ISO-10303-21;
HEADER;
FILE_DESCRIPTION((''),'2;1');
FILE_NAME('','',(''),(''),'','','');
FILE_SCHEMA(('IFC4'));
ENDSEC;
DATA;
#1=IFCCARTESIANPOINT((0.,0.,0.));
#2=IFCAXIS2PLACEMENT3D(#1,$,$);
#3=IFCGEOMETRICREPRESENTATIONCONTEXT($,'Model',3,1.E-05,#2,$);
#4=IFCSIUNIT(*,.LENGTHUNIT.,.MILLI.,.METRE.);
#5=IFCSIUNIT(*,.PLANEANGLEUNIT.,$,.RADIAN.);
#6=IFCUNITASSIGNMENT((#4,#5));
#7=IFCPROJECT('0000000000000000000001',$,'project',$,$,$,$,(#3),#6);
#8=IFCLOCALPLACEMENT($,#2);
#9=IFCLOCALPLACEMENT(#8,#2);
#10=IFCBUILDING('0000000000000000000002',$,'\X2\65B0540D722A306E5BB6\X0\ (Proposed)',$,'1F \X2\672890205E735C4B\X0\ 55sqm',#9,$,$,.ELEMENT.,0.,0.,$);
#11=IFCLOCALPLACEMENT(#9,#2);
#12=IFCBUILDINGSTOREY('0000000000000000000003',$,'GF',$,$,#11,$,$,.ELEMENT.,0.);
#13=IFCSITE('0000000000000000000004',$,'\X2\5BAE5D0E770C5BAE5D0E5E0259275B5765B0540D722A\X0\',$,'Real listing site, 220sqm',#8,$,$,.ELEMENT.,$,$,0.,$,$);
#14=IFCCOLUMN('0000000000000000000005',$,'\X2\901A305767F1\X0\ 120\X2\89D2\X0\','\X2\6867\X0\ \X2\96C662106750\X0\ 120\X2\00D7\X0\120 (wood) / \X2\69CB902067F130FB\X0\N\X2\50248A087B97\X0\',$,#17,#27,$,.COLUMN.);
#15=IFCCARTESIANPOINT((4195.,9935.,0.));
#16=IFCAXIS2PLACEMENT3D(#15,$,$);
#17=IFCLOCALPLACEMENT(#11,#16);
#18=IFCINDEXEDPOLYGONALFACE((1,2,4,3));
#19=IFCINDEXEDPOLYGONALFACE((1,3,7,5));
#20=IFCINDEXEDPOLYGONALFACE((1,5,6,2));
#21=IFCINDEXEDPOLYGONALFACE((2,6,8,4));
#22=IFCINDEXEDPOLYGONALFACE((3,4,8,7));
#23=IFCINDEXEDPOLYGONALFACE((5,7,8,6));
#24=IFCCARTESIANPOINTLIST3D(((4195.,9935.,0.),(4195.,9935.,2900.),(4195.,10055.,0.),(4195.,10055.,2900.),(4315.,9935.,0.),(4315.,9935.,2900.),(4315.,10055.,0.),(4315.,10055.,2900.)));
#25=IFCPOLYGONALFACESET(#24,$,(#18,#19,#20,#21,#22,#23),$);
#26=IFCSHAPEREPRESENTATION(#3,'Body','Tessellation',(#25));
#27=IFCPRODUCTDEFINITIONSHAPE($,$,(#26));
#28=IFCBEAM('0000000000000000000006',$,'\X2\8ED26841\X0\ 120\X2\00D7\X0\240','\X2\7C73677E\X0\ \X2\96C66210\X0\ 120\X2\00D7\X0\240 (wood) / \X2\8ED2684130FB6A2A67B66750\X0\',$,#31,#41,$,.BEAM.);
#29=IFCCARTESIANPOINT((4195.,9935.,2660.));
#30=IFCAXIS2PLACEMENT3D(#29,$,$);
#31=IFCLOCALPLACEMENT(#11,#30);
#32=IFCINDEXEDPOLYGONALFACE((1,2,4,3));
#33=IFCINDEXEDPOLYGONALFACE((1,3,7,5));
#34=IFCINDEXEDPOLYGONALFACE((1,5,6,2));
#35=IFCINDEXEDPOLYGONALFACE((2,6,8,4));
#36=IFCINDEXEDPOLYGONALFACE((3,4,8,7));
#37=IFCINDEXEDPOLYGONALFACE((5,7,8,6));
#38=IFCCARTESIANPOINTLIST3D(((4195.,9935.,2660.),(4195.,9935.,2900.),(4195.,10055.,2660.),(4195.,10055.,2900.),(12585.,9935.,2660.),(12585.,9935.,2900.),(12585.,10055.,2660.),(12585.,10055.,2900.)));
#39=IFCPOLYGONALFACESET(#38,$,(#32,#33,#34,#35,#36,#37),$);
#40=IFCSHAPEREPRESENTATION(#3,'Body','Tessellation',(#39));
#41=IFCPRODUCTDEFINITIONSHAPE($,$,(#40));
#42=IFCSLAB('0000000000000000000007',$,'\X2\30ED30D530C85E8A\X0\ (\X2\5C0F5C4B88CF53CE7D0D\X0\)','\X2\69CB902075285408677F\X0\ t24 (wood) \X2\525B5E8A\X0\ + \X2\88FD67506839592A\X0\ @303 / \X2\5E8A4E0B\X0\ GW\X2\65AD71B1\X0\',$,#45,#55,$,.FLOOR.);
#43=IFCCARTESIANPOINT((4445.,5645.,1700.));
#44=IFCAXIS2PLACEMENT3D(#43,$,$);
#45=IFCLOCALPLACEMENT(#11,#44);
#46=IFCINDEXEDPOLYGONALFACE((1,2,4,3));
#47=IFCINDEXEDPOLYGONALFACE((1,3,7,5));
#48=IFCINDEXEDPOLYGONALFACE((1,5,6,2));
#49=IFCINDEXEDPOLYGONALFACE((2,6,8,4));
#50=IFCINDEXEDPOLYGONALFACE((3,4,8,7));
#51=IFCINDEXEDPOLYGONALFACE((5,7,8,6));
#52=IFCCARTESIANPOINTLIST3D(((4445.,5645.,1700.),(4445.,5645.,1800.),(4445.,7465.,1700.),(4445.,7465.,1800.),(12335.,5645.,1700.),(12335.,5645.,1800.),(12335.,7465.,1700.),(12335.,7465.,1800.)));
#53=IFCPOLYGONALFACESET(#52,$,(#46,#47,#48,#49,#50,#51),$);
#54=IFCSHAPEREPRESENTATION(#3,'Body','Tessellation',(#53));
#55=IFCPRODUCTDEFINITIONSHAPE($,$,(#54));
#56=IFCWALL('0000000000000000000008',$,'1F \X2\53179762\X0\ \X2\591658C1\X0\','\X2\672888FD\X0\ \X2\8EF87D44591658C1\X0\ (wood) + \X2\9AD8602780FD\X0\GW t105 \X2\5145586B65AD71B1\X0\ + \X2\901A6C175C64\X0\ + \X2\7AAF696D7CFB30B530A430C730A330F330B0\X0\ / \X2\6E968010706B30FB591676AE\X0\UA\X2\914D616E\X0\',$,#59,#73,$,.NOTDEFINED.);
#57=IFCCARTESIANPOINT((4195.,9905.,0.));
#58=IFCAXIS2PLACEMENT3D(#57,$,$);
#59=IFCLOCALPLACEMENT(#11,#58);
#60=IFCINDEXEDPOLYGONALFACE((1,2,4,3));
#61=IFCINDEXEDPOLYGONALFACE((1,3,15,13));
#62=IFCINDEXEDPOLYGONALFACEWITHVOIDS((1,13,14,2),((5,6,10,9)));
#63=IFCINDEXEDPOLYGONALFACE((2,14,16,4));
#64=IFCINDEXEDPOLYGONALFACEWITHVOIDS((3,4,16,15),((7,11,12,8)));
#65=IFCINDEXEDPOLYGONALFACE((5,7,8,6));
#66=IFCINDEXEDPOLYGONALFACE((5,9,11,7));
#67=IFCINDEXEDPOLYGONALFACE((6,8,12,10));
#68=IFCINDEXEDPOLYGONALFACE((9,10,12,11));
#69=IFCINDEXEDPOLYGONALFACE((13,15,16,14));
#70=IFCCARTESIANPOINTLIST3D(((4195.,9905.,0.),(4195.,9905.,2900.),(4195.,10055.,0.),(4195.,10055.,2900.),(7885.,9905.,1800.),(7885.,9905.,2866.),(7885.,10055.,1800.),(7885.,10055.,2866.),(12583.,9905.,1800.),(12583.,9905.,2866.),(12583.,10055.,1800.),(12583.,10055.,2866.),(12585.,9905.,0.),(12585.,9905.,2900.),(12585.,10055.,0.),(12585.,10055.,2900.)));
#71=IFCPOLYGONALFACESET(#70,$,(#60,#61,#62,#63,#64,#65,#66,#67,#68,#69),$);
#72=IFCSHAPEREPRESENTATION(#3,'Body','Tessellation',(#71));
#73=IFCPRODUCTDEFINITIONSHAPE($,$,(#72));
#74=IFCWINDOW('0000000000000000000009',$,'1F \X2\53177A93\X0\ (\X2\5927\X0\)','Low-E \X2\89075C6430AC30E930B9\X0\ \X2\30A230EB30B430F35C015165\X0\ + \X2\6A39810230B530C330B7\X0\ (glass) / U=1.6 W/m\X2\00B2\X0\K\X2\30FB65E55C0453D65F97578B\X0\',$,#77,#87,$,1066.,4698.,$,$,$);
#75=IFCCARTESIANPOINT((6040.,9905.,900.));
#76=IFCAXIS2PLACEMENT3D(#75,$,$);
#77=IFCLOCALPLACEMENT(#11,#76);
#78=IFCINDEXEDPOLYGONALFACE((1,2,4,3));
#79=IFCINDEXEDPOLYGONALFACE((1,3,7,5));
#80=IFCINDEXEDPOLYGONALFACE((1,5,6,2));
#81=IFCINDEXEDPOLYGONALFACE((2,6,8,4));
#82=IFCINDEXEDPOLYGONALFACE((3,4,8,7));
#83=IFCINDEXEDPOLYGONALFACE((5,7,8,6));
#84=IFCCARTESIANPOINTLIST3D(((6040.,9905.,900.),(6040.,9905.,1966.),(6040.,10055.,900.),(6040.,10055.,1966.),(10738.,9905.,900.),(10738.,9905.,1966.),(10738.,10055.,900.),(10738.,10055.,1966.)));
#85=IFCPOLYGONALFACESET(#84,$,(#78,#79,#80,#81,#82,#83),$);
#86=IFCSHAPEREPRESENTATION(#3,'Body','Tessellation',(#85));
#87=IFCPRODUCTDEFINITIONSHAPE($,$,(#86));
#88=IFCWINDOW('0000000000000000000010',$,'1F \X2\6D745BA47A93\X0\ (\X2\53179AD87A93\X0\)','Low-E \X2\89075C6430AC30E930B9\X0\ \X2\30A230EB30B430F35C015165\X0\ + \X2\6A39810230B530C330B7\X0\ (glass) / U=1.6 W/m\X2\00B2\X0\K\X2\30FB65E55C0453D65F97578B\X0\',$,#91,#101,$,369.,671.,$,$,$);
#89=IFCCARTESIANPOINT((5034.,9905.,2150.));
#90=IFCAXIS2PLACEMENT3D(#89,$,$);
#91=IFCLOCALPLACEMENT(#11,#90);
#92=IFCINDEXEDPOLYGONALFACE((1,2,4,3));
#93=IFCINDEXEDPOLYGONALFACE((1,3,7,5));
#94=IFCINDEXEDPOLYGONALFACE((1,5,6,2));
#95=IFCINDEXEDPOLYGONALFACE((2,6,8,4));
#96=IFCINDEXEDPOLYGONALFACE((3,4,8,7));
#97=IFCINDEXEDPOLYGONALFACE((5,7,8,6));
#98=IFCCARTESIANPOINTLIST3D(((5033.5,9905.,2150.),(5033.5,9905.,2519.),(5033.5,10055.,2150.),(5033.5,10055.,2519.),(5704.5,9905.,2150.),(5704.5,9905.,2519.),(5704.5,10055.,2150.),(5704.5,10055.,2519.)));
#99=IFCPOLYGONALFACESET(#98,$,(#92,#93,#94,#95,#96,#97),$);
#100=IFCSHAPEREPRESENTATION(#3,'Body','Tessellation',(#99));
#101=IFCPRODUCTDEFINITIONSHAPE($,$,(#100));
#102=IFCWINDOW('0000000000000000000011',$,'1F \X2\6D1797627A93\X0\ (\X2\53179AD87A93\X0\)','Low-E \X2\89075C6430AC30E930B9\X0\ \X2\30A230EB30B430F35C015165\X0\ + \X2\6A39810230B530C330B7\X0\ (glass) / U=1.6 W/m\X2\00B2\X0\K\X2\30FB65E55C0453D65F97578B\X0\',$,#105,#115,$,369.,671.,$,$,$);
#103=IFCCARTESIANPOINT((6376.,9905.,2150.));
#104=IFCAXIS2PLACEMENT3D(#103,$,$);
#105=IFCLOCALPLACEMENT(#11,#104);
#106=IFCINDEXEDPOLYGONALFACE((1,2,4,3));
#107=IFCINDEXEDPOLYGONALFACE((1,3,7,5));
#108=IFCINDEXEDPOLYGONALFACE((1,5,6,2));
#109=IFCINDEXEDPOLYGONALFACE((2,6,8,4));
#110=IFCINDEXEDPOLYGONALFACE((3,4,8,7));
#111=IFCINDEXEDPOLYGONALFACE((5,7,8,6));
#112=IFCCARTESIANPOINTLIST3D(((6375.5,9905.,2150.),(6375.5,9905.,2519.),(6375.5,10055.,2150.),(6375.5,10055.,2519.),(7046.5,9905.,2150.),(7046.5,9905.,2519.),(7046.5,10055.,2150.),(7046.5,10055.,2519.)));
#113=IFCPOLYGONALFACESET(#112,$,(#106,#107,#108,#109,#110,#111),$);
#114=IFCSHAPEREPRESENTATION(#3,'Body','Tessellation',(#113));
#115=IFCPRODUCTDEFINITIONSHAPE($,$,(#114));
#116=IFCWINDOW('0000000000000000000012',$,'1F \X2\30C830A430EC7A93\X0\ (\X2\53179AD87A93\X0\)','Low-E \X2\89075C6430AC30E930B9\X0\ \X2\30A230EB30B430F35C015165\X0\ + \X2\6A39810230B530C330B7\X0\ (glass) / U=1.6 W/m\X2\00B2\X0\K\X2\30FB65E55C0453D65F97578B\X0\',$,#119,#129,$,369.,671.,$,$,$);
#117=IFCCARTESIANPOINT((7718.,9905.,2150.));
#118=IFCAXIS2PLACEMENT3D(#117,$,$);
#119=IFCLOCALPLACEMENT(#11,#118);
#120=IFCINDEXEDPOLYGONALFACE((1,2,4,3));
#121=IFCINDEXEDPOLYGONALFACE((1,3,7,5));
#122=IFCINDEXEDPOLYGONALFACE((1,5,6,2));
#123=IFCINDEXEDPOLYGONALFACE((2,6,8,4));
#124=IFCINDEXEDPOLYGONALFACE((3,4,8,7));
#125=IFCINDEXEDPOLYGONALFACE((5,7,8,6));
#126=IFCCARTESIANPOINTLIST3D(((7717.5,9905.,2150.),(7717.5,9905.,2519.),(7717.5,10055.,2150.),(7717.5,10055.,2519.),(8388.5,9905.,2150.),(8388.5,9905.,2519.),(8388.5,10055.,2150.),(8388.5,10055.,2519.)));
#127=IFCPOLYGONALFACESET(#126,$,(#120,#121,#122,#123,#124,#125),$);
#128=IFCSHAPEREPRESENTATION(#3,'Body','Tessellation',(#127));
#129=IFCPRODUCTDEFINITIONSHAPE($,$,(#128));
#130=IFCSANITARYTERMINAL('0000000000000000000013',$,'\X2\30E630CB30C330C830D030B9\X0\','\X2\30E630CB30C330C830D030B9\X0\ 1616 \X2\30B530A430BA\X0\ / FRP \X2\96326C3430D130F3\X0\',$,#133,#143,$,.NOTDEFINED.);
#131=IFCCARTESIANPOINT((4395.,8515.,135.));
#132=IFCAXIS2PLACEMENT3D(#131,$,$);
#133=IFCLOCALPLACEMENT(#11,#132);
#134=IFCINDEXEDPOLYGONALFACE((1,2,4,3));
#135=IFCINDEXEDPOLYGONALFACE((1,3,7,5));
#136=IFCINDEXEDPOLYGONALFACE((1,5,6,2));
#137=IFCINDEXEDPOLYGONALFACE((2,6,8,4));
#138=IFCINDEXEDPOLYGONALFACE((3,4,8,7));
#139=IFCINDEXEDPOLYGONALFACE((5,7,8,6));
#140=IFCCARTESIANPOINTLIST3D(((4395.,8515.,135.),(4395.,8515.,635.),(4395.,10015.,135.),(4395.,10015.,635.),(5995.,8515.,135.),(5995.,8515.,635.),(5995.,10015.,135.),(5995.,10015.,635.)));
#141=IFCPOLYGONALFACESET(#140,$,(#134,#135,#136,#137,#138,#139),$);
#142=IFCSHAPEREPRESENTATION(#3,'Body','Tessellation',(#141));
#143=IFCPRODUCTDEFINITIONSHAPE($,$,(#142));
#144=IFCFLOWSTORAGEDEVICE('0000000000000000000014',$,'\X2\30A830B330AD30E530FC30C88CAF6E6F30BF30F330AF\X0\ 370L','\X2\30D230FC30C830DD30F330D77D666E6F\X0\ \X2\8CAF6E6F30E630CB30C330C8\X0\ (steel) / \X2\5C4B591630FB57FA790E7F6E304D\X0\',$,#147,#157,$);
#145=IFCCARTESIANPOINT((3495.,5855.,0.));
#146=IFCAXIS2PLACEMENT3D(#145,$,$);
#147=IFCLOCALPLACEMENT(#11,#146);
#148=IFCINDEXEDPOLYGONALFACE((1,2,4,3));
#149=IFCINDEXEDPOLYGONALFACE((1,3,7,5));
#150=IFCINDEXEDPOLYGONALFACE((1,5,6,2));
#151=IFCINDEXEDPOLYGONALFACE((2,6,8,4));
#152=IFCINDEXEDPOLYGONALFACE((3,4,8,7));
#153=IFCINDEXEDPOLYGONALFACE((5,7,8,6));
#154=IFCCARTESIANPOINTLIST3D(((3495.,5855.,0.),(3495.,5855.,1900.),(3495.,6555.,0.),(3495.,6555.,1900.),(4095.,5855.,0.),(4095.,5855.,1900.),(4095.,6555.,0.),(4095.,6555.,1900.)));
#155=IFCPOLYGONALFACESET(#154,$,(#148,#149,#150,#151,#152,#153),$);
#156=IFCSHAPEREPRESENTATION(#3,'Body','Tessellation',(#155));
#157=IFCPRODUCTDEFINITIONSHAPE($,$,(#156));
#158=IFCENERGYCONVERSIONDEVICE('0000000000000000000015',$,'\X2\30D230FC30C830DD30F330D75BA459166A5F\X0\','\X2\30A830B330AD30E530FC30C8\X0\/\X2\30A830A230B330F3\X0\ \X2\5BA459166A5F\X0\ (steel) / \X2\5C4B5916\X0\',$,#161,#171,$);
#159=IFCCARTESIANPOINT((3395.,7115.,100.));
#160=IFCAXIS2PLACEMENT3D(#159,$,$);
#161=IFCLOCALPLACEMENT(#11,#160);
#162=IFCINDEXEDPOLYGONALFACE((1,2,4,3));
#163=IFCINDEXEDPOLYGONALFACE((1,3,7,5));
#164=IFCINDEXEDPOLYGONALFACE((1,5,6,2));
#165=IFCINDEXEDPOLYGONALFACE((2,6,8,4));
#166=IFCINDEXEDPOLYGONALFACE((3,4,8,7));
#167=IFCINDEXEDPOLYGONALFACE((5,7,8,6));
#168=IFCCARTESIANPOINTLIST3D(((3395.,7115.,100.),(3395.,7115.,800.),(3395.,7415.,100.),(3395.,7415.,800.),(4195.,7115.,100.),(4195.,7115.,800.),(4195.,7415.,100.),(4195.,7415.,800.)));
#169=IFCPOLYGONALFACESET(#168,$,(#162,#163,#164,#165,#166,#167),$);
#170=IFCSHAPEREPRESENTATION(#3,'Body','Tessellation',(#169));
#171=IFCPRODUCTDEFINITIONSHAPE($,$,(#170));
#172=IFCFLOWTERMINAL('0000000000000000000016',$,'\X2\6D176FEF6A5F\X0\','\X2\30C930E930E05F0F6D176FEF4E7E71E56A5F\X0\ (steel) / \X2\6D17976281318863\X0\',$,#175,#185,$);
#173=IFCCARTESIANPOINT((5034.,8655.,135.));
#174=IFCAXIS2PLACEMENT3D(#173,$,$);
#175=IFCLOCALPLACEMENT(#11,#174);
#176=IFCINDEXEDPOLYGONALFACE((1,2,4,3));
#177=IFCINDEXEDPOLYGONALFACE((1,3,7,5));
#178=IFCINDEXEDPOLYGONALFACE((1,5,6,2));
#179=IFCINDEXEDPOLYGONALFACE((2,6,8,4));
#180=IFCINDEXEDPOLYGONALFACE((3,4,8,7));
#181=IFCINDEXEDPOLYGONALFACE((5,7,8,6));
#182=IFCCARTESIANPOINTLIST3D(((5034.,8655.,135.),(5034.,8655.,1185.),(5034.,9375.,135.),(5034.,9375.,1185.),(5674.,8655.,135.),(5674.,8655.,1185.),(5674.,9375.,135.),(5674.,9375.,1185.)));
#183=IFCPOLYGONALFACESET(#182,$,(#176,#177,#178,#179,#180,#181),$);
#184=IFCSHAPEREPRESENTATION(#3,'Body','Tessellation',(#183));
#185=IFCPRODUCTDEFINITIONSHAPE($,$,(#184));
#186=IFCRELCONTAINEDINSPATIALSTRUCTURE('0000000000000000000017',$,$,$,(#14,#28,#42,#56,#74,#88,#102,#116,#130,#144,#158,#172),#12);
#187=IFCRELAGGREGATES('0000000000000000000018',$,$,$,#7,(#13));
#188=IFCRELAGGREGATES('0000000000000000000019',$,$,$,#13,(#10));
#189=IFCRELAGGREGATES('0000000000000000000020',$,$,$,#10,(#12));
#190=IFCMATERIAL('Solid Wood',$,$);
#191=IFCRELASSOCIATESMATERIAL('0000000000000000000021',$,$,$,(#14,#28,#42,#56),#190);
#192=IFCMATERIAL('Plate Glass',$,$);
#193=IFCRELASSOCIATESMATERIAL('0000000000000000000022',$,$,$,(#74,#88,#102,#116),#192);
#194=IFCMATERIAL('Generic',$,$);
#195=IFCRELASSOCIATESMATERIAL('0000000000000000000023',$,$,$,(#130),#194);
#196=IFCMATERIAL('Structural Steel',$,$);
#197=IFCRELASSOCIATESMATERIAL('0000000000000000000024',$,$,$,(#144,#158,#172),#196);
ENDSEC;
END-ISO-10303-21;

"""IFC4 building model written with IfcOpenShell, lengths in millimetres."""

from ifc_helpers import new_model, si_unit, frame, frame_2d, origin, place, context, project, spatial, rectangle, extrude, material, element, fill, save


model = new_model("IFC4")

# Units and contexts
model_context = context("Model", 3, precision=1e-05, world=origin())
ifc_project = project(units=[si_unit("LENGTHUNIT", "METRE", prefix="MILLI"), si_unit("PLANEANGLEUNIT", "RADIAN")], contexts=[model_context])

# Site, building, storey
site_placement = place(None, origin())
site = spatial("IfcSite", under=ifc_project, at=site_placement, Name="宮崎県宮崎市大字新名爪", ObjectType="Real listing site, 220sqm", CompositionType="ELEMENT", RefElevation=0.0)
building_placement = place(site_placement, origin())
building = spatial("IfcBuilding", under=site, at=building_placement, Name="新名爪の家 (Proposed)", ObjectType="1F 木造平屋 55sqm", CompositionType="ELEMENT", ElevationOfRefHeight=0.0, ElevationOfTerrain=0.0)
storey_placement = place(building_placement, origin())
storey = spatial("IfcBuildingStorey", under=building, at=storey_placement, Name="GF", CompositionType="ELEMENT", Elevation=0.0)

# Column
ifc_material_1 = material(Name="Solid Wood")
column_1_placement = place(storey_placement, frame((4195.0, 9935.0, 0.0)))
element("IfcColumn", 1, at=column_1_placement, inside=storey, material=ifc_material_1, Name="通し柱 120角", Description="桧 集成材 120×120 (wood) / 構造柱・N値計算", PredefinedType="COLUMN", context=model_context, shape_type="SweptSolid", body=[
    extrude(rectangle(XDim=120.0, YDim=120.0, at=frame_2d((60.0, 60.0))), frame((4195.0, 9935.0, 0.0)), (0.0, 0.0, 1.0), 2900.0),
])

# Beam
beam_1_placement = place(storey_placement, frame((4195.0, 9935.0, 2660.0)))
element("IfcBeam", 2, at=beam_1_placement, inside=storey, material=ifc_material_1, Name="軒桁 120×240", Description="米松 集成 120×240 (wood) / 軒桁・横架材", PredefinedType="BEAM", context=model_context, shape_type="SweptSolid", body=[
    extrude(rectangle(XDim=8390.0, YDim=120.0, at=frame_2d((4195.0, 60.0))), frame((4195.0, 9935.0, 2660.0)), (0.0, 0.0, 1.0), 240.0),
])

# Slab
slab_placement = place(storey_placement, frame((4445.0, 5645.0, 1700.0)))
element("IfcSlab", 3, at=slab_placement, inside=storey, material=ifc_material_1, Name="ロフト床 (小屋裏収納)", Description="構造用合板 t24 (wood) 剛床 + 製材根太 @303 / 床下 GW断熱", PredefinedType="FLOOR", context=model_context, shape_type="SweptSolid", body=[
    extrude(rectangle(XDim=7890.0, YDim=1820.0, at=frame_2d((3945.0, 910.0))), frame((4445.0, 5645.0, 1700.0)), (0.0, 0.0, 1.0), 100.0),
])

# Wall, openings, windows
wall_1_placement = place(storey_placement, frame((4195.0, 9905.0, 0.0)))
wall_1 = element("IfcWall", 4, at=wall_1_placement, inside=storey, material=ifc_material_1, Name="1F 北面 外壁", Description="木製 軸組外壁 (wood) + 高性能GW t105 充填断熱 + 通気層 + 窯業系サイディング / 準耐火・外皮UA配慮", PredefinedType="NOTDEFINED", context=model_context, shape_type="SweptSolid", body=[
    extrude(rectangle(XDim=8390.0, YDim=150.0, at=frame_2d((4195.0, 75.0))), frame((4195.0, 9905.0, 0.0)), (0.0, 0.0, 1.0), 2900.0),
])
opening_1_placement = place(storey_placement, frame((6040.0, 9905.0, 900.0)))
opening_1 = element("IfcOpeningElement", 5, at=opening_1_placement, cuts=wall_1, PredefinedType="NOTDEFINED", context=model_context, shape_type="SweptSolid", body=[
    extrude(rectangle(XDim=4698.0, YDim=150.0, at=frame_2d((2349.0, 75.0))), frame((6040.0, 9905.0, 900.0)), (0.0, 0.0, 1.0), 1066.0),
])
opening_2_placement = place(storey_placement, frame((5034.0, 9905.0, 2150.0)))
opening_2 = element("IfcOpeningElement", 6, at=opening_2_placement, cuts=wall_1, PredefinedType="NOTDEFINED", context=model_context, shape_type="SweptSolid", body=[
    extrude(rectangle(XDim=671.0, YDim=150.0, at=frame_2d((335.0, 75.0))), frame((5034.0, 9905.0, 2150.0)), (0.0, 0.0, 1.0), 369.0),
])
opening_3_placement = place(storey_placement, frame((6376.0, 9905.0, 2150.0)))
opening_3 = element("IfcOpeningElement", 7, at=opening_3_placement, cuts=wall_1, PredefinedType="NOTDEFINED", context=model_context, shape_type="SweptSolid", body=[
    extrude(rectangle(XDim=671.0, YDim=150.0, at=frame_2d((335.0, 75.0))), frame((6376.0, 9905.0, 2150.0)), (0.0, 0.0, 1.0), 369.0),
])
opening_4_placement = place(storey_placement, frame((7718.0, 9905.0, 2150.0)))
opening_4 = element("IfcOpeningElement", 8, at=opening_4_placement, cuts=wall_1, PredefinedType="NOTDEFINED", context=model_context, shape_type="SweptSolid", body=[
    extrude(rectangle(XDim=671.0, YDim=150.0, at=frame_2d((335.0, 75.0))), frame((7718.0, 9905.0, 2150.0)), (0.0, 0.0, 1.0), 369.0),
])
ifc_material_2 = material(Name="Plate Glass")
window_1_placement = place(storey_placement, frame((6040.0, 9905.0, 900.0)))
window_1 = element("IfcWindow", 9, at=window_1_placement, inside=storey, material=ifc_material_2, Name="1F 北窓 (大)", Description="Low-E 複層ガラス アルゴン封入 + 樹脂サッシ (glass) / U=1.6 W/m²K・日射取得型", OverallHeight=1066.0, OverallWidth=4698.0, context=model_context, shape_type="SweptSolid", body=[
    extrude(rectangle(XDim=4698.0, YDim=150.0, at=frame_2d((2349.0, 75.0))), frame((6040.0, 9905.0, 900.0)), (0.0, 0.0, 1.0), 1066.0),
])
fill(opening_1, window_1)
window_2_placement = place(storey_placement, frame((5034.0, 9905.0, 2150.0)))
window_2 = element("IfcWindow", 10, at=window_2_placement, inside=storey, material=ifc_material_2, Name="1F 浴室窓 (北高窓)", Description="Low-E 複層ガラス アルゴン封入 + 樹脂サッシ (glass) / U=1.6 W/m²K・日射取得型", OverallHeight=369.0, OverallWidth=671.0, context=model_context, shape_type="SweptSolid", body=[
    extrude(rectangle(XDim=671.0, YDim=150.0, at=frame_2d((335.0, 75.0))), frame((5034.0, 9905.0, 2150.0)), (0.0, 0.0, 1.0), 369.0),
])
fill(opening_2, window_2)
window_3_placement = place(storey_placement, frame((6376.0, 9905.0, 2150.0)))
window_3 = element("IfcWindow", 11, at=window_3_placement, inside=storey, material=ifc_material_2, Name="1F 洗面窓 (北高窓)", Description="Low-E 複層ガラス アルゴン封入 + 樹脂サッシ (glass) / U=1.6 W/m²K・日射取得型", OverallHeight=369.0, OverallWidth=671.0, context=model_context, shape_type="SweptSolid", body=[
    extrude(rectangle(XDim=671.0, YDim=150.0, at=frame_2d((335.0, 75.0))), frame((6376.0, 9905.0, 2150.0)), (0.0, 0.0, 1.0), 369.0),
])
fill(opening_3, window_3)
window_4_placement = place(storey_placement, frame((7718.0, 9905.0, 2150.0)))
window_4 = element("IfcWindow", 12, at=window_4_placement, inside=storey, material=ifc_material_2, Name="1F トイレ窓 (北高窓)", Description="Low-E 複層ガラス アルゴン封入 + 樹脂サッシ (glass) / U=1.6 W/m²K・日射取得型", OverallHeight=369.0, OverallWidth=671.0, context=model_context, shape_type="SweptSolid", body=[
    extrude(rectangle(XDim=671.0, YDim=150.0, at=frame_2d((335.0, 75.0))), frame((7718.0, 9905.0, 2150.0)), (0.0, 0.0, 1.0), 369.0),
])
fill(opening_4, window_4)

# Sanitary terminal
ifc_material_3 = material(Name="Generic")
sanitary_terminal_placement = place(storey_placement, frame((4395.0, 8515.0, 135.0)))
element("IfcSanitaryTerminal", 13, at=sanitary_terminal_placement, inside=storey, material=ifc_material_3, Name="ユニットバス", Description="ユニットバス 1616 サイズ / FRP 防水パン", PredefinedType="NOTDEFINED", context=model_context, shape_type="SweptSolid", body=[
    extrude(rectangle(XDim=1600.0, YDim=1500.0, at=frame_2d((800.0, 750.0))), frame((4395.0, 8515.0, 135.0)), (0.0, 0.0, 1.0), 500.0),
])

# Flow storage device
ifc_material_4 = material(Name="Structural Steel")
flow_storage_device_placement = place(storey_placement, frame((3495.0, 5855.0, 0.0)))
element("IfcFlowStorageDevice", 14, at=flow_storage_device_placement, inside=storey, material=ifc_material_4, Name="エコキュート貯湯タンク 370L", Description="ヒートポンプ給湯 貯湯ユニット (steel) / 屋外・基礎置き", context=model_context, shape_type="SweptSolid", body=[
    extrude(rectangle(XDim=600.0, YDim=700.0, at=frame_2d((300.0, 350.0))), frame((3495.0, 5855.0, 0.0)), (0.0, 0.0, 1.0), 1900.0),
])

# Energy conversion device
energy_conversion_device_placement = place(storey_placement, frame((3395.0, 7115.0, 100.0)))
element("IfcEnergyConversionDevice", 15, at=energy_conversion_device_placement, inside=storey, material=ifc_material_4, Name="ヒートポンプ室外機", Description="エコキュート/エアコン 室外機 (steel) / 屋外", context=model_context, shape_type="SweptSolid", body=[
    extrude(rectangle(XDim=800.0, YDim=300.0, at=frame_2d((400.0, 150.0))), frame((3395.0, 7115.0, 100.0)), (0.0, 0.0, 1.0), 700.0),
])

# Flow terminal
flow_terminal_placement = place(storey_placement, frame((5034.0, 8655.0, 135.0)))
element("IfcFlowTerminal", 16, at=flow_terminal_placement, inside=storey, material=ifc_material_4, Name="洗濯機", Description="ドラム式洗濯乾燥機 (steel) / 洗面脱衣", context=model_context, shape_type="SweptSolid", body=[
    extrude(rectangle(XDim=640.0, YDim=720.0, at=frame_2d((320.0, 360.0))), frame((5034.0, 8655.0, 135.0)), (0.0, 0.0, 1.0), 1050.0),
])

save(model, "model.ifc")
